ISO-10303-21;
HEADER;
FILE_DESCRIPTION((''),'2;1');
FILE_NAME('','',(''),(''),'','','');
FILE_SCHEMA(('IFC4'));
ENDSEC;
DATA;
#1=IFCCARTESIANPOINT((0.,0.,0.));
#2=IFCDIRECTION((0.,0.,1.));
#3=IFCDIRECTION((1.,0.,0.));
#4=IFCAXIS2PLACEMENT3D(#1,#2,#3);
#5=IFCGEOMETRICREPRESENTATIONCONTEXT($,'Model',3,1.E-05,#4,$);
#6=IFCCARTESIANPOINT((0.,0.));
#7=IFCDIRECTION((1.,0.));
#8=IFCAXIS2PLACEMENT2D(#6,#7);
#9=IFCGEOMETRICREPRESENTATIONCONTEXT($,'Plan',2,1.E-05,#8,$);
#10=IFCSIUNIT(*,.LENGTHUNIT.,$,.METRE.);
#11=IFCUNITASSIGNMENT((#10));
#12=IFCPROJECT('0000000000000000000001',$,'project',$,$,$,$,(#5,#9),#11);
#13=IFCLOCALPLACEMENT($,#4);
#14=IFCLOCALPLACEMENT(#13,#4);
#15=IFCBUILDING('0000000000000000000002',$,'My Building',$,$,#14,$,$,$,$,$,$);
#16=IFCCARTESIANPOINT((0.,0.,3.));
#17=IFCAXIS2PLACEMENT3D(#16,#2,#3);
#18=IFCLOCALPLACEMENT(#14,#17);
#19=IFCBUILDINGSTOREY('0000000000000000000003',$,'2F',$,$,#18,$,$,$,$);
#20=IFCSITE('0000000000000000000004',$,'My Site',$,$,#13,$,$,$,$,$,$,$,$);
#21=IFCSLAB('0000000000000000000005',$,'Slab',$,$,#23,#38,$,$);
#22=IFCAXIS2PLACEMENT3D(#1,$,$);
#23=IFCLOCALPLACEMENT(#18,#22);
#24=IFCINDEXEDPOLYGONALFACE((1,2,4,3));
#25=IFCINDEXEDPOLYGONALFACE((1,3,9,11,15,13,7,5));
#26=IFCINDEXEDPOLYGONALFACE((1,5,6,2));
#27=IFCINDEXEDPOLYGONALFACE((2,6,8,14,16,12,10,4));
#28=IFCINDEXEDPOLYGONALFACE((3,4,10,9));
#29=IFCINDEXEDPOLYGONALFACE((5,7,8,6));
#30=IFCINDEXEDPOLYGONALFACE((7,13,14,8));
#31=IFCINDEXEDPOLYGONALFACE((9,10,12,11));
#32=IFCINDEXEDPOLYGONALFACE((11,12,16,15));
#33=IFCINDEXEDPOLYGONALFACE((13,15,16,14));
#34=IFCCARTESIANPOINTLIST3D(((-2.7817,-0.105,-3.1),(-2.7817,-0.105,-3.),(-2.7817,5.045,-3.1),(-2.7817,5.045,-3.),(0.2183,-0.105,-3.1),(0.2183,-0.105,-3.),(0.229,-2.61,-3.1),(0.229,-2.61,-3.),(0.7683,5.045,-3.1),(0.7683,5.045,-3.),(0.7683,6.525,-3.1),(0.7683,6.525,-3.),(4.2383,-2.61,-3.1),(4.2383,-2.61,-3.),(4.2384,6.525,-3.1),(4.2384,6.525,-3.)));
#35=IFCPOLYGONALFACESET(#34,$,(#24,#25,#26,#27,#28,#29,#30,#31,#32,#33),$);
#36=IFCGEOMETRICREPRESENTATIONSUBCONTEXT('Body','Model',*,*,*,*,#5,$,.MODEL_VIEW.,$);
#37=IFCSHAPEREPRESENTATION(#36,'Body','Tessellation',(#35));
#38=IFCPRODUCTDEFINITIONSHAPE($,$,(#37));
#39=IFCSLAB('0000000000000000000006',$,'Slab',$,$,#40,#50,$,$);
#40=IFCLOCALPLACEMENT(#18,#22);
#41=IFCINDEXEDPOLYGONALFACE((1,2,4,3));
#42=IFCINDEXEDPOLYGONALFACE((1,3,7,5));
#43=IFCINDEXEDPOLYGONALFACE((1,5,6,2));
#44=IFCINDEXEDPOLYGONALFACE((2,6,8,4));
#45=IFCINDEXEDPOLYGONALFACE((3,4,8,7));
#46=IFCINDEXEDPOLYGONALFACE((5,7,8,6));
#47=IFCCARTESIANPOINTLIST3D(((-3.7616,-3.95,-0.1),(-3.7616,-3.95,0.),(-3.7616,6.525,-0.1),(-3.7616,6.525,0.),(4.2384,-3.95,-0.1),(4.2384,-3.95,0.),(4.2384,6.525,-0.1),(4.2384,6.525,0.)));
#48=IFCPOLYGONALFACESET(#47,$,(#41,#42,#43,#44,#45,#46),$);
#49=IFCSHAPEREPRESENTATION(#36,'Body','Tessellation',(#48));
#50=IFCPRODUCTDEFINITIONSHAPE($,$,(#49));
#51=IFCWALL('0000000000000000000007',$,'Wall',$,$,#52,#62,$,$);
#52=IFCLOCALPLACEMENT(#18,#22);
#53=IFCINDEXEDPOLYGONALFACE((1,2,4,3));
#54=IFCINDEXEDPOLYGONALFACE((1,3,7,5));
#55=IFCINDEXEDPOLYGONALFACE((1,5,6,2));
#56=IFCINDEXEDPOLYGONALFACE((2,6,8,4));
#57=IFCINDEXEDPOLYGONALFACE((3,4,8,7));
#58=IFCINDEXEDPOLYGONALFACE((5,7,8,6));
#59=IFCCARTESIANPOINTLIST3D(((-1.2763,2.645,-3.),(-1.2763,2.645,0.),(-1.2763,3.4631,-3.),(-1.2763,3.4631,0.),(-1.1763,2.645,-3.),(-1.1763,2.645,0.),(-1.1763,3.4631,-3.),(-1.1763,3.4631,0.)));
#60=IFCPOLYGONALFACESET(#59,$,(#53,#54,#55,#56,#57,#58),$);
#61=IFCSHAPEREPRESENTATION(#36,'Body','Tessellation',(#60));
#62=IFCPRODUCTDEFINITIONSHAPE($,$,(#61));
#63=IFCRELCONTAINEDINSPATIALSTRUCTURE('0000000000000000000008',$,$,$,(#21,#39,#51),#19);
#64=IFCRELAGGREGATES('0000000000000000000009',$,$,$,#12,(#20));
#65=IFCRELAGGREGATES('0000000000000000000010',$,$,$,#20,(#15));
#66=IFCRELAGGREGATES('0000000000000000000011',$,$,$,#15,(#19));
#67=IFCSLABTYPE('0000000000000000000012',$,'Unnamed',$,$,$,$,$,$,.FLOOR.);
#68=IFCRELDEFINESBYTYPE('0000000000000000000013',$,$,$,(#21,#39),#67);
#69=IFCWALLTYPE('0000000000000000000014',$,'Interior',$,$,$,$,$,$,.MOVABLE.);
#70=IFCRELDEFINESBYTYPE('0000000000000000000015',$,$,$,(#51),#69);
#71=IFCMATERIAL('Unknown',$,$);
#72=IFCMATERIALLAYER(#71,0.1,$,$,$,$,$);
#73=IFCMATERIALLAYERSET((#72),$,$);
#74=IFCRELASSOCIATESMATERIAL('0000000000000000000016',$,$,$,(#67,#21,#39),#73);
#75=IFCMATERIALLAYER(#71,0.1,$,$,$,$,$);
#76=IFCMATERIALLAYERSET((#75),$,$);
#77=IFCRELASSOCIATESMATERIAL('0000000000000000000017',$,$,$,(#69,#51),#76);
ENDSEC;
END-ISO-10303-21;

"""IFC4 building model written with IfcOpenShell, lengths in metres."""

from ifc_helpers import new_model, si_unit, frame, origin_with_axes, origin_2d_with_axis, place, context, subcontext, project, spatial, line, indexed_curve, outline, extrude, material, layer, layer_set, layer_usage, type_object, element, save


model = new_model("IFC4")

# Units and contexts
model_context = context("Model", 3, precision=1e-05, world=origin_with_axes())
plan_context = context("Plan", 2, precision=1e-05, world=origin_2d_with_axis())
body_context_1 = subcontext(model_context, "Body", "Model", "MODEL_VIEW")
ifc_project = project(units=[si_unit("LENGTHUNIT", "METRE")], contexts=[model_context, plan_context])

# Site, building, storey
site_placement = place(None, origin_with_axes())
site = spatial("IfcSite", under=ifc_project, at=site_placement, Name="My Site")
building_placement = place(site_placement, origin_with_axes())
building = spatial("IfcBuilding", under=site, at=building_placement, Name="My Building")
storey_placement = place(building_placement, frame((0.0, 0.0, 3.0), z_axis=(0.0, 0.0, 1.0), x_axis=(1.0, 0.0, 0.0)))
storey = spatial("IfcBuildingStorey", under=building, at=storey_placement, Name="2F")

# Slabs
ifc_material = material(Name="Unknown")
ifc_layer_1 = layer(ifc_material, 0.1)
ifc_layer_set_1 = layer_set([ifc_layer_1])
ifc_layer_usage_1 = layer_usage(ifc_layer_set_1, "AXIS3", "POSITIVE", -0.1)
slab_type = type_object("IfcSlabType", Name="Unnamed", PredefinedType="FLOOR", material=ifc_layer_set_1)
slab_1_placement = place(storey_placement, frame((4.2383, -2.61, -3.0), z_axis=(0.0, 0.0, 1.0), x_axis=(1.0, 0.0, 0.0)))
element("IfcSlab", 1, at=slab_1_placement, inside=storey, type_object=slab_type, material=ifc_layer_usage_1, Name="Slab", context=body_context_1, shape_type="SweptSolid", body=[
    extrude(outline(indexed_curve([(0.0, 0.0), (0.0, 9.135), (-3.47, 9.135), (-3.47, 7.655), (-7.02, 7.655), (-7.02, 2.505), (-4.02, 2.505), (-4.0094, 0.0), (0.0, 0.0)])), frame((0.0, 0.0, -0.1), z_axis=(0.0, 0.0, 1.0), x_axis=(1.0, 0.0, 0.0)), (0.0, 0.0, 1.0), 0.1),
])
ifc_layer_usage_2 = layer_usage(ifc_layer_set_1, "AXIS3", "POSITIVE", -0.1)
slab_2_placement = place(storey_placement, frame((4.2384, 6.525, 0.0), z_axis=(0.0, 0.0, 1.0), x_axis=(1.0, 0.0, 0.0)))
element("IfcSlab", 2, at=slab_2_placement, inside=storey, type_object=slab_type, material=ifc_layer_usage_2, Name="Slab", context=body_context_1, shape_type="SweptSolid", body=[
    extrude(outline(indexed_curve([(0.0, 0.0), (-8.0, 0.0), (-8.0, -10.475), (0.0, -10.475), (0.0, 0.0)])), frame((0.0, 0.0, -0.1), z_axis=(0.0, 0.0, 1.0), x_axis=(1.0, 0.0, 0.0)), (0.0, 0.0, 1.0), 0.1),
])

# Wall
ifc_layer_2 = layer(ifc_material, 0.1)
ifc_layer_set_2 = layer_set([ifc_layer_2])
ifc_layer_usage_3 = layer_usage(ifc_layer_set_2, "AXIS2", "POSITIVE", 0.0)
wall_type = type_object("IfcWallType", Name="Interior", PredefinedType="MOVABLE", material=ifc_layer_set_2)
wall_1_placement = place(storey_placement, frame((-1.2763, 3.4631, -3.0), z_axis=(0.0, 0.0, 1.0), x_axis=(0.0, -1.0, 0.0)))
element("IfcWall", 3, at=wall_1_placement, inside=storey, type_object=wall_type, material=ifc_layer_usage_3, Name="Wall", context=body_context_1, shape_type="SweptSolid", body=[
    extrude(outline(indexed_curve([(0.0, 0.0), (0.0, 0.1), (0.8182, 0.1), (0.8182, 0.0)], segments=[line(1, 2, 3, 4, 1)])), origin_with_axes(), (0.0, 0.0, 1.0), 3.0),
])

save(model, "model.ifc")
